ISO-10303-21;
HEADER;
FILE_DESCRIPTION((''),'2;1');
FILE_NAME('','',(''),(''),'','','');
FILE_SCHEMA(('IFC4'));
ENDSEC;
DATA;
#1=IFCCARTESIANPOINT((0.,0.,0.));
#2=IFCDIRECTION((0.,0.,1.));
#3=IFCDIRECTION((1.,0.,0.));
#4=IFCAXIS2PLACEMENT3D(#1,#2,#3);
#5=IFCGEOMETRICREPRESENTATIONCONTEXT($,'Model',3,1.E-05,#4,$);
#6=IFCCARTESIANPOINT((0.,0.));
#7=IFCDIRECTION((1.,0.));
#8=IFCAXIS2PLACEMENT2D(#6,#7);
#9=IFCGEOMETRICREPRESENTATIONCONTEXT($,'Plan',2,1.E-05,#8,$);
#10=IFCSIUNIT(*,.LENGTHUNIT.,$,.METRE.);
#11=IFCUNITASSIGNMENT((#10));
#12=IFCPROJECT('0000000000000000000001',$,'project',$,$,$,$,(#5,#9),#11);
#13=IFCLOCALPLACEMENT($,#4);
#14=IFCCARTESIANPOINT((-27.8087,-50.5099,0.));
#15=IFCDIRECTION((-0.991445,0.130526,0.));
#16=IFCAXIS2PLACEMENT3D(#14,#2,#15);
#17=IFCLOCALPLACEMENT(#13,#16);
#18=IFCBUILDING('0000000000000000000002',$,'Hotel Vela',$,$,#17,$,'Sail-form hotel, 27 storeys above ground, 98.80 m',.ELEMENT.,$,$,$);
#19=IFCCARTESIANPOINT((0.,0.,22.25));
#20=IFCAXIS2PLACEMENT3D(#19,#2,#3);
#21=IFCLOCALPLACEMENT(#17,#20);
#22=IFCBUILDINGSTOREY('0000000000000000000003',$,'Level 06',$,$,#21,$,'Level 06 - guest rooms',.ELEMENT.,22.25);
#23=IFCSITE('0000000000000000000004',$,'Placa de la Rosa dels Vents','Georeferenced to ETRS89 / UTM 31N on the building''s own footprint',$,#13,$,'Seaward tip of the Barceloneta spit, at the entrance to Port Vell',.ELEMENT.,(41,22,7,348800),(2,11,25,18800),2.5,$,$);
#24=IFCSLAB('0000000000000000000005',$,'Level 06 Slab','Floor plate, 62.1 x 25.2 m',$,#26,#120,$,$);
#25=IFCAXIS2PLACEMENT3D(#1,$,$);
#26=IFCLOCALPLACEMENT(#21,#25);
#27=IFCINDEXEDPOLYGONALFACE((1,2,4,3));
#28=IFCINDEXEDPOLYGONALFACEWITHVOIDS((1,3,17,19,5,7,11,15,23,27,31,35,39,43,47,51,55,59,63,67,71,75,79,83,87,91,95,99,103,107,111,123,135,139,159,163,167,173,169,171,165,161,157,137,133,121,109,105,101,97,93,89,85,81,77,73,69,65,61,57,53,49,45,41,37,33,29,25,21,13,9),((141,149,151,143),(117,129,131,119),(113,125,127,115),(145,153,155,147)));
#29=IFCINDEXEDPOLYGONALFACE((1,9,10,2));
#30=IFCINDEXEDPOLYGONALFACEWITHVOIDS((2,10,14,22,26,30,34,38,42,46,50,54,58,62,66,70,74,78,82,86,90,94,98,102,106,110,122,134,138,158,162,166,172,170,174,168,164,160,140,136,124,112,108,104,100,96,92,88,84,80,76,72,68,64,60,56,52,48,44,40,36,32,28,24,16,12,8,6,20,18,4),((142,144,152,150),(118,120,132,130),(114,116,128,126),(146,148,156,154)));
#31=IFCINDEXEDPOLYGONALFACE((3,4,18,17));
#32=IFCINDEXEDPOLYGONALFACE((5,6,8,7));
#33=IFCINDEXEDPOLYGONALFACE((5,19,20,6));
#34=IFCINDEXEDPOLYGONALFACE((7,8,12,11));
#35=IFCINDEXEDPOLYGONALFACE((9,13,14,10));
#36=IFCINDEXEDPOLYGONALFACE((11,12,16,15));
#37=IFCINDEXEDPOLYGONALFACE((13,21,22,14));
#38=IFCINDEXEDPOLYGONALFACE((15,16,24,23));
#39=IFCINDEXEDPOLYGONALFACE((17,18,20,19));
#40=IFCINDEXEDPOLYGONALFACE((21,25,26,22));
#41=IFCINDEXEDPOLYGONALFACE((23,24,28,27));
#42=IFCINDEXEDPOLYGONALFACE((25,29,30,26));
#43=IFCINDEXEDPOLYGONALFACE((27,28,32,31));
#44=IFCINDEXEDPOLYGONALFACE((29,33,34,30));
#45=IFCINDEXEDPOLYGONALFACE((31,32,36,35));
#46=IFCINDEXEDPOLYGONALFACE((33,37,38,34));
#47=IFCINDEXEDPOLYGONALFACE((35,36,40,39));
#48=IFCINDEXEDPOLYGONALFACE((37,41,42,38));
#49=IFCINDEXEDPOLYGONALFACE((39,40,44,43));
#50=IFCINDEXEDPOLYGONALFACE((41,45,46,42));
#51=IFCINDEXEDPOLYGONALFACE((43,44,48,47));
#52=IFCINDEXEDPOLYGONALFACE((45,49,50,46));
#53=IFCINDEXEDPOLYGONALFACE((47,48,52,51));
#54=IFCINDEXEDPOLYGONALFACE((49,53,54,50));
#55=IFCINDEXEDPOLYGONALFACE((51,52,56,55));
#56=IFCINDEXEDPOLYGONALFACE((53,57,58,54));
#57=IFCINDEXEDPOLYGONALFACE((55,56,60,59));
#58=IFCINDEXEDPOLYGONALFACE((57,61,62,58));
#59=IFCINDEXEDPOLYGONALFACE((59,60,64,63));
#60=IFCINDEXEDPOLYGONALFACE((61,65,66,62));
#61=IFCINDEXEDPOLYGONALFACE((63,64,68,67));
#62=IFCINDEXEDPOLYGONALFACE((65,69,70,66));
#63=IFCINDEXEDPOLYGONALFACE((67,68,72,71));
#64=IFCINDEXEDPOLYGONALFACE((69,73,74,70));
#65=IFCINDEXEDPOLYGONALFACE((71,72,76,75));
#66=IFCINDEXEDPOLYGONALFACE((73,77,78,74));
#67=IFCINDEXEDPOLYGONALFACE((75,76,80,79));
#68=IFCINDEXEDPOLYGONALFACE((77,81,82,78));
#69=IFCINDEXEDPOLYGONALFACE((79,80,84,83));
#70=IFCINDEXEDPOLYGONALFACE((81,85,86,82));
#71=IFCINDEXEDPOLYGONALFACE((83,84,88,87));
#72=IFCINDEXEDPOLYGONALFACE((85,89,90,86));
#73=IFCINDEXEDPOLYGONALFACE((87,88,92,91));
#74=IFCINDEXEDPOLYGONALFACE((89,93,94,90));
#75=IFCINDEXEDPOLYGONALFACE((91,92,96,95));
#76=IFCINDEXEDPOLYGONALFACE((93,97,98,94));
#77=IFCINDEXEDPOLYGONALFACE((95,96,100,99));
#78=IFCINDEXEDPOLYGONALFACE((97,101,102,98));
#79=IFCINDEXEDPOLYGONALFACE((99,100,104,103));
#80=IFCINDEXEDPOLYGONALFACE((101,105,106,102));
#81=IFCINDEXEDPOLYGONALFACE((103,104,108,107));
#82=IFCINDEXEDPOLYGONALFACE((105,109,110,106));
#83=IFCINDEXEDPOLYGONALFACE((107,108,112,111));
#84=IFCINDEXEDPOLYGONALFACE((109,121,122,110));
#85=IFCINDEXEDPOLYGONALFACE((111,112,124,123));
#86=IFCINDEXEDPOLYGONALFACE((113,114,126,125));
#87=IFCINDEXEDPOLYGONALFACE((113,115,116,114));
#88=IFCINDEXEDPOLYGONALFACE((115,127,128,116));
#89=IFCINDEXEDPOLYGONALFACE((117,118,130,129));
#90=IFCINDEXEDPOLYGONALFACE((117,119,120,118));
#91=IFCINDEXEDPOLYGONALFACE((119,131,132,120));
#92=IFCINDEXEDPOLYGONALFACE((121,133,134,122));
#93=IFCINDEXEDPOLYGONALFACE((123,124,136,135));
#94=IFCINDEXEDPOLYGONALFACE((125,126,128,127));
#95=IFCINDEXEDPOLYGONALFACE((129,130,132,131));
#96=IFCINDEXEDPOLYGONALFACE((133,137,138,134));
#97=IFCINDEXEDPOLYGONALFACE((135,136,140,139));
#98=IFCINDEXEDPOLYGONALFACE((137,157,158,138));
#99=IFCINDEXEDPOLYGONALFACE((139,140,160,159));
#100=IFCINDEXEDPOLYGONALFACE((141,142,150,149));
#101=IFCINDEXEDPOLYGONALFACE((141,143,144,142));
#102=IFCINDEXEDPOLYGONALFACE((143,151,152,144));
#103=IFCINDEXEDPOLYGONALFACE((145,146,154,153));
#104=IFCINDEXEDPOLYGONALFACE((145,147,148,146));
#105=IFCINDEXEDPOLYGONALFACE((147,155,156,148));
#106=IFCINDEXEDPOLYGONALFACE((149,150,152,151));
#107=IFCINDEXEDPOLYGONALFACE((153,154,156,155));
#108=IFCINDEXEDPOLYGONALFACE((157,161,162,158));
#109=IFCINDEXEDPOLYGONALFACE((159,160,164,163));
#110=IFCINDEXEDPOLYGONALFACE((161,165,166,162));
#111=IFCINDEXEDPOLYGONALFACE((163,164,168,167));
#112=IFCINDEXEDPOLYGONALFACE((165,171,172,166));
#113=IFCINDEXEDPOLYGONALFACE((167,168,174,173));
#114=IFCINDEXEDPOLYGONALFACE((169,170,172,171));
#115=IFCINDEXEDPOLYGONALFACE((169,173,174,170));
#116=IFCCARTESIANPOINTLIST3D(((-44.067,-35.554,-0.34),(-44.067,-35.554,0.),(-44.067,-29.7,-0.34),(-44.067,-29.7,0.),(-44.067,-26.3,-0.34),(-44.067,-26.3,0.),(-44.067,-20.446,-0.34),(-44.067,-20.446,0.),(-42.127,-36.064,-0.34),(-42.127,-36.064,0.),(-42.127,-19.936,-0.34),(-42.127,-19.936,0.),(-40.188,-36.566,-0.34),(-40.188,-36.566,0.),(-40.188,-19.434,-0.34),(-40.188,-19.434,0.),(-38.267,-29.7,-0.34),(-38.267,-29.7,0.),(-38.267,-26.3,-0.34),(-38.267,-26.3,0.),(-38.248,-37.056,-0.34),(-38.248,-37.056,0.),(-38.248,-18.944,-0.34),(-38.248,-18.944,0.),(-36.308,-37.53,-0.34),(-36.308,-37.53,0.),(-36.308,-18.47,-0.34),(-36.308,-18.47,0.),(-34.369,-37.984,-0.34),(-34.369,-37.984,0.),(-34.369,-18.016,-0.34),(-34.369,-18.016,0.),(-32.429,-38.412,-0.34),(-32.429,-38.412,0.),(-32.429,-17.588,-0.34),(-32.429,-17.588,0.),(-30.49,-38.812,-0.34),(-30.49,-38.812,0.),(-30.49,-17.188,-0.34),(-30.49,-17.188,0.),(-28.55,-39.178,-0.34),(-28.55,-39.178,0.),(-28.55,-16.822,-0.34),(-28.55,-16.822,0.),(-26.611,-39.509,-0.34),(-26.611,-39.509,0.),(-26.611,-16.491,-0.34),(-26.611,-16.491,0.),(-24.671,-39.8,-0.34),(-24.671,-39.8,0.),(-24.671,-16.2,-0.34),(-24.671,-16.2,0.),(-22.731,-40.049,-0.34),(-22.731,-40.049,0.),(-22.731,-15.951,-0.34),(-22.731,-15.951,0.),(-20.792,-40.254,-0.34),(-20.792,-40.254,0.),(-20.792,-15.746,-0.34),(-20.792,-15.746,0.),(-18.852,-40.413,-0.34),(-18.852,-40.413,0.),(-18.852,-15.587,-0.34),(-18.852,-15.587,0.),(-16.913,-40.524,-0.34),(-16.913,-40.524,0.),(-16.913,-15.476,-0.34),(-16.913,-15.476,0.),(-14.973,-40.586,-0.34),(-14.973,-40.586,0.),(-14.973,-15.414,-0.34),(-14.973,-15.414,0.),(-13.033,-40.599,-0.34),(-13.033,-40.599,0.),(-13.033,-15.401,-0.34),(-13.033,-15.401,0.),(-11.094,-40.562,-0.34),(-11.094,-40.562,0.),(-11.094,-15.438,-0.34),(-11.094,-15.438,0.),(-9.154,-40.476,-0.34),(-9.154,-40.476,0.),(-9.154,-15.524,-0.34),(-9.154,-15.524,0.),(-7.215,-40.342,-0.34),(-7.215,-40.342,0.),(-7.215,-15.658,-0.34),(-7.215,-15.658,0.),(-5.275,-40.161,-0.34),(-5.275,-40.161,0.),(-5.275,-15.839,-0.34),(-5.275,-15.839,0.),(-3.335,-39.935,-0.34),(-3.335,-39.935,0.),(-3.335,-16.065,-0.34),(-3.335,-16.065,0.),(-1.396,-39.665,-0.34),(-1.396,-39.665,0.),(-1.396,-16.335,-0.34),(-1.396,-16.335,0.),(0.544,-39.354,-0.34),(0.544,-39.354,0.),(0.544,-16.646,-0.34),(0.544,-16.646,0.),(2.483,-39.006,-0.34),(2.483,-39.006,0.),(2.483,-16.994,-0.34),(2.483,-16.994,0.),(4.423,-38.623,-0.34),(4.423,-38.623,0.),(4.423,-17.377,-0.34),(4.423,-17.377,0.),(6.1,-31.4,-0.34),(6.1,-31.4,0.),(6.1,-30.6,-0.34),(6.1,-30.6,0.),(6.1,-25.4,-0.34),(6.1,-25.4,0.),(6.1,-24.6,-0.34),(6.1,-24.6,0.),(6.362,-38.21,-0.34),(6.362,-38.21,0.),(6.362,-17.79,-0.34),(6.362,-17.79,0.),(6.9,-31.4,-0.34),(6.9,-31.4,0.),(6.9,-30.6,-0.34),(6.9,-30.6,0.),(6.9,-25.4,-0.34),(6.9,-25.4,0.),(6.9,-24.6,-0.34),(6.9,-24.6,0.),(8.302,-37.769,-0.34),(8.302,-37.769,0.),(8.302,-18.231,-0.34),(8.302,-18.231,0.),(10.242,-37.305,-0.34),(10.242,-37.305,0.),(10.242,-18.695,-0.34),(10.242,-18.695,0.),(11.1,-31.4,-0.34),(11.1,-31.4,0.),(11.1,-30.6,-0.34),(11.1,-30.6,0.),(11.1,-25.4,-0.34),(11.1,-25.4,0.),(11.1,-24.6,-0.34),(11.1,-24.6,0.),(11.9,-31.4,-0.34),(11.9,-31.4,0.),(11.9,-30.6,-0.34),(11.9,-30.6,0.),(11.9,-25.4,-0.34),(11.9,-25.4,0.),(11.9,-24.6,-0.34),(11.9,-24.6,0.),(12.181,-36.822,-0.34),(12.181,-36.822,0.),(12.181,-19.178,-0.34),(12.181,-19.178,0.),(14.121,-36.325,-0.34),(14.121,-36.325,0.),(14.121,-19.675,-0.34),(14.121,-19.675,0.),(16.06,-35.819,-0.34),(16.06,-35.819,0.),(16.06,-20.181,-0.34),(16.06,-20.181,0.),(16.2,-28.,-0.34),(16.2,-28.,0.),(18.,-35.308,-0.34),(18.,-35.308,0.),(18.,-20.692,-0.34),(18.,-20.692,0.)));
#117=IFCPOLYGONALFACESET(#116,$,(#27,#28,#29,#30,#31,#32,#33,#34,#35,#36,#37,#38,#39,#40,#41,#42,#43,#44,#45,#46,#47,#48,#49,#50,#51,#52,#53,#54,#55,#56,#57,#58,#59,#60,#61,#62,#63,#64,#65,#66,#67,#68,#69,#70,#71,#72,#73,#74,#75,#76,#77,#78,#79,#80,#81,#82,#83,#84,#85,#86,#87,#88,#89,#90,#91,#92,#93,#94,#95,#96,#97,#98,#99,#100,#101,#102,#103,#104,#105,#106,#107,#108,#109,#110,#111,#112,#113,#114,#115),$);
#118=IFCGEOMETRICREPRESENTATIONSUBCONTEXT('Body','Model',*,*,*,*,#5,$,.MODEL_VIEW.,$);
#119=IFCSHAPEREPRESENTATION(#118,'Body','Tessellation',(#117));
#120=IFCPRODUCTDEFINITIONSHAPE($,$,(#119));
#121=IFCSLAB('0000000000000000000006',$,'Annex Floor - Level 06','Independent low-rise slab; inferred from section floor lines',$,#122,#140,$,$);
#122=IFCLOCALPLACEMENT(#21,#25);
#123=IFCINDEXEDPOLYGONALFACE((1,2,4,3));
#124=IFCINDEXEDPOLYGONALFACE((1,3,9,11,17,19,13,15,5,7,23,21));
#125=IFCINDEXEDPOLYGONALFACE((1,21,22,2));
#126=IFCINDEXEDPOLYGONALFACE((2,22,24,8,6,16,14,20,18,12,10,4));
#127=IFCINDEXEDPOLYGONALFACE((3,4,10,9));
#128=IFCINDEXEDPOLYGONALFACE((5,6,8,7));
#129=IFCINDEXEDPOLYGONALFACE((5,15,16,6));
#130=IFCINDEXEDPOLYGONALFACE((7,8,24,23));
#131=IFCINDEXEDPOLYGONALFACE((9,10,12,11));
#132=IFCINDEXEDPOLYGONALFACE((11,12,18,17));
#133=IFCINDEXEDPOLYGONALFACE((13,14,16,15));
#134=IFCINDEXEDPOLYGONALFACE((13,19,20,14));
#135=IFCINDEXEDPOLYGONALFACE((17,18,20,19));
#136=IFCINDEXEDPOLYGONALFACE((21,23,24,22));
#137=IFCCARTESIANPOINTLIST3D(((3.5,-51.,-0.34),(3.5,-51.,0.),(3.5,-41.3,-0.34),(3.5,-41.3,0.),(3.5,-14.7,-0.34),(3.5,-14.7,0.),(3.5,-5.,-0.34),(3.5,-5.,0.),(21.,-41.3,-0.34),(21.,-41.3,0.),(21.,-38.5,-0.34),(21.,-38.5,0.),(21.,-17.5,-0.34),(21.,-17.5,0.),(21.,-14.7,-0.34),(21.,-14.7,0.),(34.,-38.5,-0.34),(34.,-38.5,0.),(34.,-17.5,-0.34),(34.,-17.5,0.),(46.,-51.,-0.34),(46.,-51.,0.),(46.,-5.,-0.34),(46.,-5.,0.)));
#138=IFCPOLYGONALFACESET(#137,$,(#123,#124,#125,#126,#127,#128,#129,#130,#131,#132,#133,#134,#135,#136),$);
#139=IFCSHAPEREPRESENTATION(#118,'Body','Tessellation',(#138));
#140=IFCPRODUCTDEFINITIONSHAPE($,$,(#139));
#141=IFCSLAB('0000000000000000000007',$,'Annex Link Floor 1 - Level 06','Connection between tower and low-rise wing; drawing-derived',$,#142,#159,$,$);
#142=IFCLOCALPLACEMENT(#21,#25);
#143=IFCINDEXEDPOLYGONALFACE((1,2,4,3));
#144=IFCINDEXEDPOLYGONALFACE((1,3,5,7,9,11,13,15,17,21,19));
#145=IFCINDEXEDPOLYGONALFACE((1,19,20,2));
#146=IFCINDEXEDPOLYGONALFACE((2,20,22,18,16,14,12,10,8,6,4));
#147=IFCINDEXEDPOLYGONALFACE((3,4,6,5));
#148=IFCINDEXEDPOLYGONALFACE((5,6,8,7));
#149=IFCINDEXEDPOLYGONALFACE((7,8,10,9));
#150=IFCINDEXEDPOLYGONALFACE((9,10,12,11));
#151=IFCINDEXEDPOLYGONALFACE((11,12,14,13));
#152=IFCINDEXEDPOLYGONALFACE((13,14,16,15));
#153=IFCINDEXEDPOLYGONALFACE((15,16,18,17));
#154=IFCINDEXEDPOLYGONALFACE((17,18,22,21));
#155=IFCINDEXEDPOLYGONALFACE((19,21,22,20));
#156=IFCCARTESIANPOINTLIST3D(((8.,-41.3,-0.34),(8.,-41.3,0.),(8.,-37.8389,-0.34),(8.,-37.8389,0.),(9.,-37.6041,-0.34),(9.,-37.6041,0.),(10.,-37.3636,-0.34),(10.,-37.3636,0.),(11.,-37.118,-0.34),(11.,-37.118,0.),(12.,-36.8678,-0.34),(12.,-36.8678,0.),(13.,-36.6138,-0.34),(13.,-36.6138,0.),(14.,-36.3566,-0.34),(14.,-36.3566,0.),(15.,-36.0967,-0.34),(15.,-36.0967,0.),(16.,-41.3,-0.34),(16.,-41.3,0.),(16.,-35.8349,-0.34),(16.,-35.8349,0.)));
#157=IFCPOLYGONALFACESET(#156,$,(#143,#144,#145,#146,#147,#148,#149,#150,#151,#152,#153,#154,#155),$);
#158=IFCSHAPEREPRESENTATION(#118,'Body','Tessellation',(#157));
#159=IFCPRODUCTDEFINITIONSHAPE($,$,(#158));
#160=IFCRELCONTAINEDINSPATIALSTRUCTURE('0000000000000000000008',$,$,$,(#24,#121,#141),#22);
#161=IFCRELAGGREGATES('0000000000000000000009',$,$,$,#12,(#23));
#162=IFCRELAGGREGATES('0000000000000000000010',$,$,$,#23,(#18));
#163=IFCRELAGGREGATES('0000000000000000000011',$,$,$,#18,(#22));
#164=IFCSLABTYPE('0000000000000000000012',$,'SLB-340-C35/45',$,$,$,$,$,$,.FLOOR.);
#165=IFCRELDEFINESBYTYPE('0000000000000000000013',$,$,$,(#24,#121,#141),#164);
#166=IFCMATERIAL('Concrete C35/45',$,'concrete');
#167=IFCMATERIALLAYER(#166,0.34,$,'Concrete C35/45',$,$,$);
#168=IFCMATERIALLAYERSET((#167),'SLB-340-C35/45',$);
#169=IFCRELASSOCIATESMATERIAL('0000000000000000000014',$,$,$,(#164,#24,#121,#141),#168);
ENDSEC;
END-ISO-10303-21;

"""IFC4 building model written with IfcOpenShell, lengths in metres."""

from ifc_helpers import new_model, si_unit, frame, origin_with_axes, origin_2d_with_axis, place, context, subcontext, project, spatial, line, indexed_curve, outline, extrude, material, layer, layer_set, layer_usage, type_object, element, save


model = new_model("IFC4")

# Units and contexts
model_context = context("Model", 3, precision=1e-05, world=origin_with_axes())
plan_context = context("Plan", 2, precision=1e-05, world=origin_2d_with_axis())
body_context = subcontext(model_context, "Body", "Model", "MODEL_VIEW")
ifc_project = project(units=[si_unit("LENGTHUNIT", "METRE")], contexts=[model_context, plan_context])

# Site, building, storey
site_placement = place(None, origin_with_axes())
site = spatial("IfcSite", under=ifc_project, at=site_placement, Name="Placa de la Rosa dels Vents", Description="Georeferenced to ETRS89 / UTM 31N on the building's own footprint", LongName="Seaward tip of the Barceloneta spit, at the entrance to Port Vell", CompositionType="ELEMENT", RefLatitude=(41, 22, 7, 348800), RefLongitude=(2, 11, 25, 18800), RefElevation=2.5)
building_placement = place(site_placement, frame((-27.8087, -50.5099, 0.0), z_axis=(0.0, 0.0, 1.0), x_axis=(-0.991445, 0.130526, 0.0)))
building = spatial("IfcBuilding", under=site, at=building_placement, Name="Hotel Vela", LongName="Sail-form hotel, 27 storeys above ground, 98.80 m", CompositionType="ELEMENT")
storey_placement = place(building_placement, frame((0.0, 0.0, 22.25), z_axis=(0.0, 0.0, 1.0), x_axis=(1.0, 0.0, 0.0)))
storey = spatial("IfcBuildingStorey", under=building, at=storey_placement, Name="Level 06", LongName="Level 06 - guest rooms", CompositionType="ELEMENT", Elevation=22.25)

# Shared definitions
ifc_material = material(Name="Concrete C35/45", Category="concrete")

# Slab, openings
ifc_layer_1 = layer(ifc_material, 0.34, Name="Concrete C35/45")
ifc_layer_set_1 = layer_set([ifc_layer_1], Name="SLB-340-C35/45")
ifc_layer_usage_1 = layer_usage(ifc_layer_set_1, "AXIS3", "POSITIVE", 0.0)
slab_type = type_object("IfcSlabType", Name="SLB-340-C35/45", PredefinedType="FLOOR", material=ifc_layer_set_1)
slab_1_placement = place(storey_placement, frame((0.0, 0.0, -0.34), z_axis=(0.0, 0.0, 1.0), x_axis=(1.0, 0.0, 0.0)))
slab_1 = element("IfcSlab", 1, at=slab_1_placement, inside=storey, type_object=slab_type, material=ifc_layer_usage_1, Name="Level 06 Slab", Description="Floor plate, 62.1 x 25.2 m", context=body_context, shape_type="SweptSolid", body=[
    extrude(outline(indexed_curve([(-44.067, -35.554), (-42.127, -36.064), (-40.188, -36.566), (-38.248, -37.056), (-36.308, -37.53), (-34.369, -37.984), (-32.429, -38.412), (-30.49, -38.812), (-28.55, -39.178), (-26.611, -39.509), (-24.671, -39.8), (-22.731, -40.049), (-20.792, -40.254), (-18.852, -40.413), (-16.913, -40.524), (-14.973, -40.586), (-13.033, -40.599), (-11.094, -40.562), (-9.154, -40.476), (-7.215, -40.342), (-5.275, -40.161), (-3.335, -39.935), (-1.396, -39.665), (0.544, -39.354), (2.483, -39.006), (4.423, -38.623), (6.362, -38.21), (8.302, -37.769), (10.242, -37.305), (12.181, -36.822), (14.121, -36.325), (16.06, -35.819), (18.0, -35.308), (16.2, -28.0), (18.0, -20.692), (16.06, -20.181), (14.121, -19.675), (12.181, -19.178), (10.242, -18.695), (8.302, -18.231), (6.362, -17.79), (4.423, -17.377), (2.483, -16.994), (0.544, -16.646), (-1.396, -16.335), (-3.335, -16.065), (-5.275, -15.839), (-7.215, -15.658), (-9.154, -15.524), (-11.094, -15.438), (-13.033, -15.401), (-14.973, -15.414), (-16.913, -15.476), (-18.852, -15.587), (-20.792, -15.746), (-22.731, -15.951), (-24.671, -16.2), (-26.611, -16.491), (-28.55, -16.822), (-30.49, -17.188), (-32.429, -17.588), (-34.369, -18.016), (-36.308, -18.47), (-38.248, -18.944), (-40.188, -19.434), (-42.127, -19.936), (-44.067, -20.446), (-44.067, -26.3), (-38.267, -26.3), (-38.267, -29.7), (-44.067, -29.7)], segments=[line(1, 2, 3, 4, 5, 6, 7, 8, 9, 10, 11, 12, 13, 14, 15, 16, 17, 18, 19, 20, 21, 22, 23, 24, 25, 26, 27, 28, 29, 30, 31, 32, 33, 34, 35, 36, 37, 38, 39, 40, 41, 42, 43, 44, 45, 46, 47, 48, 49, 50, 51, 52, 53, 54, 55, 56, 57, 58, 59, 60, 61, 62, 63, 64, 65, 66, 67, 68, 69, 70, 71, 1)])), origin_with_axes(), (0.0, 0.0, 1.0), 0.34),
])
opening_1_placement = place(slab_1_placement, frame((6.1, -31.4, -0.05), z_axis=(0.0, 0.0, 1.0), x_axis=(1.0, 0.0, 0.0)))
element("IfcOpeningElement", 2, at=opening_1_placement, cuts=slab_1, PredefinedType="OPENING", context=body_context, shape_type="SweptSolid", body=[
    extrude(outline(indexed_curve([(0.0, 0.0), (0.8, 0.0), (0.8, 0.8), (0.0, 0.8)], segments=[line(1, 2, 3, 4, 1)])), origin_with_axes(), (0.0, 0.0, 1.0), 0.44),
])
opening_2_placement = place(slab_1_placement, frame((6.1, -25.4, -0.05), z_axis=(0.0, 0.0, 1.0), x_axis=(1.0, 0.0, 0.0)))
element("IfcOpeningElement", 3, at=opening_2_placement, cuts=slab_1, PredefinedType="OPENING", context=body_context, shape_type="SweptSolid", body=[
    extrude(outline(indexed_curve([(0.0, 0.0), (0.8, 0.0), (0.8, 0.8), (0.0, 0.8)], segments=[line(1, 2, 3, 4, 1)])), origin_with_axes(), (0.0, 0.0, 1.0), 0.44),
])
opening_3_placement = place(slab_1_placement, frame((11.1, -31.4, -0.05), z_axis=(0.0, 0.0, 1.0), x_axis=(1.0, 0.0, 0.0)))
element("IfcOpeningElement", 4, at=opening_3_placement, cuts=slab_1, PredefinedType="OPENING", context=body_context, shape_type="SweptSolid", body=[
    extrude(outline(indexed_curve([(0.0, 0.0), (0.8, 0.0), (0.8, 0.8), (0.0, 0.8)], segments=[line(1, 2, 3, 4, 1)])), origin_with_axes(), (0.0, 0.0, 1.0), 0.44),
])
opening_4_placement = place(slab_1_placement, frame((11.1, -25.4, -0.05), z_axis=(0.0, 0.0, 1.0), x_axis=(1.0, 0.0, 0.0)))
element("IfcOpeningElement", 5, at=opening_4_placement, cuts=slab_1, PredefinedType="OPENING", context=body_context, shape_type="SweptSolid", body=[
    extrude(outline(indexed_curve([(0.0, 0.0), (0.8, 0.0), (0.8, 0.8), (0.0, 0.8)], segments=[line(1, 2, 3, 4, 1)])), origin_with_axes(), (0.0, 0.0, 1.0), 0.44),
])

# Slabs
ifc_layer_usage_2 = layer_usage(ifc_layer_set_1, "AXIS3", "POSITIVE", 0.0)
slab_2_placement = place(storey_placement, frame((0.0, 0.0, -0.34), z_axis=(0.0, 0.0, 1.0), x_axis=(1.0, 0.0, 0.0)))
element("IfcSlab", 6, at=slab_2_placement, inside=storey, type_object=slab_type, material=ifc_layer_usage_2, Name="Annex Floor - Level 06", Description="Independent low-rise slab; inferred from section floor lines", context=body_context, shape_type="SweptSolid", body=[
    extrude(outline(indexed_curve([(3.5, -51.0), (46.0, -51.0), (46.0, -5.0), (3.5, -5.0), (3.5, -14.7), (21.0, -14.7), (21.0, -17.5), (34.0, -17.5), (34.0, -38.5), (21.0, -38.5), (21.0, -41.3), (3.5, -41.3)], segments=[line(1, 2, 3, 4, 5, 6, 7, 8, 9, 10, 11, 12, 1)])), origin_with_axes(), (0.0, 0.0, 1.0), 0.34),
])
ifc_layer_usage_3 = layer_usage(ifc_layer_set_1, "AXIS3", "POSITIVE", 0.0)
slab_3_placement = place(storey_placement, frame((0.0, 0.0, -0.34), z_axis=(0.0, 0.0, 1.0), x_axis=(1.0, 0.0, 0.0)))
element("IfcSlab", 7, at=slab_3_placement, inside=storey, type_object=slab_type, material=ifc_layer_usage_3, Name="Annex Link Floor 1 - Level 06", Description="Connection between tower and low-rise wing; drawing-derived", context=body_context, shape_type="SweptSolid", body=[
    extrude(outline(indexed_curve([(8.0, -41.3), (16.0, -41.3), (16.0, -35.8349), (15.0, -36.0967), (14.0, -36.3566), (13.0, -36.6138), (12.0, -36.8678), (11.0, -37.118), (10.0, -37.3636), (9.0, -37.6041), (8.0, -37.8389)], segments=[line(1, 2, 3, 4, 5, 6, 7, 8, 9, 10, 11, 1)])), origin_with_axes(), (0.0, 0.0, 1.0), 0.34),
])

save(model, "model.ifc")
